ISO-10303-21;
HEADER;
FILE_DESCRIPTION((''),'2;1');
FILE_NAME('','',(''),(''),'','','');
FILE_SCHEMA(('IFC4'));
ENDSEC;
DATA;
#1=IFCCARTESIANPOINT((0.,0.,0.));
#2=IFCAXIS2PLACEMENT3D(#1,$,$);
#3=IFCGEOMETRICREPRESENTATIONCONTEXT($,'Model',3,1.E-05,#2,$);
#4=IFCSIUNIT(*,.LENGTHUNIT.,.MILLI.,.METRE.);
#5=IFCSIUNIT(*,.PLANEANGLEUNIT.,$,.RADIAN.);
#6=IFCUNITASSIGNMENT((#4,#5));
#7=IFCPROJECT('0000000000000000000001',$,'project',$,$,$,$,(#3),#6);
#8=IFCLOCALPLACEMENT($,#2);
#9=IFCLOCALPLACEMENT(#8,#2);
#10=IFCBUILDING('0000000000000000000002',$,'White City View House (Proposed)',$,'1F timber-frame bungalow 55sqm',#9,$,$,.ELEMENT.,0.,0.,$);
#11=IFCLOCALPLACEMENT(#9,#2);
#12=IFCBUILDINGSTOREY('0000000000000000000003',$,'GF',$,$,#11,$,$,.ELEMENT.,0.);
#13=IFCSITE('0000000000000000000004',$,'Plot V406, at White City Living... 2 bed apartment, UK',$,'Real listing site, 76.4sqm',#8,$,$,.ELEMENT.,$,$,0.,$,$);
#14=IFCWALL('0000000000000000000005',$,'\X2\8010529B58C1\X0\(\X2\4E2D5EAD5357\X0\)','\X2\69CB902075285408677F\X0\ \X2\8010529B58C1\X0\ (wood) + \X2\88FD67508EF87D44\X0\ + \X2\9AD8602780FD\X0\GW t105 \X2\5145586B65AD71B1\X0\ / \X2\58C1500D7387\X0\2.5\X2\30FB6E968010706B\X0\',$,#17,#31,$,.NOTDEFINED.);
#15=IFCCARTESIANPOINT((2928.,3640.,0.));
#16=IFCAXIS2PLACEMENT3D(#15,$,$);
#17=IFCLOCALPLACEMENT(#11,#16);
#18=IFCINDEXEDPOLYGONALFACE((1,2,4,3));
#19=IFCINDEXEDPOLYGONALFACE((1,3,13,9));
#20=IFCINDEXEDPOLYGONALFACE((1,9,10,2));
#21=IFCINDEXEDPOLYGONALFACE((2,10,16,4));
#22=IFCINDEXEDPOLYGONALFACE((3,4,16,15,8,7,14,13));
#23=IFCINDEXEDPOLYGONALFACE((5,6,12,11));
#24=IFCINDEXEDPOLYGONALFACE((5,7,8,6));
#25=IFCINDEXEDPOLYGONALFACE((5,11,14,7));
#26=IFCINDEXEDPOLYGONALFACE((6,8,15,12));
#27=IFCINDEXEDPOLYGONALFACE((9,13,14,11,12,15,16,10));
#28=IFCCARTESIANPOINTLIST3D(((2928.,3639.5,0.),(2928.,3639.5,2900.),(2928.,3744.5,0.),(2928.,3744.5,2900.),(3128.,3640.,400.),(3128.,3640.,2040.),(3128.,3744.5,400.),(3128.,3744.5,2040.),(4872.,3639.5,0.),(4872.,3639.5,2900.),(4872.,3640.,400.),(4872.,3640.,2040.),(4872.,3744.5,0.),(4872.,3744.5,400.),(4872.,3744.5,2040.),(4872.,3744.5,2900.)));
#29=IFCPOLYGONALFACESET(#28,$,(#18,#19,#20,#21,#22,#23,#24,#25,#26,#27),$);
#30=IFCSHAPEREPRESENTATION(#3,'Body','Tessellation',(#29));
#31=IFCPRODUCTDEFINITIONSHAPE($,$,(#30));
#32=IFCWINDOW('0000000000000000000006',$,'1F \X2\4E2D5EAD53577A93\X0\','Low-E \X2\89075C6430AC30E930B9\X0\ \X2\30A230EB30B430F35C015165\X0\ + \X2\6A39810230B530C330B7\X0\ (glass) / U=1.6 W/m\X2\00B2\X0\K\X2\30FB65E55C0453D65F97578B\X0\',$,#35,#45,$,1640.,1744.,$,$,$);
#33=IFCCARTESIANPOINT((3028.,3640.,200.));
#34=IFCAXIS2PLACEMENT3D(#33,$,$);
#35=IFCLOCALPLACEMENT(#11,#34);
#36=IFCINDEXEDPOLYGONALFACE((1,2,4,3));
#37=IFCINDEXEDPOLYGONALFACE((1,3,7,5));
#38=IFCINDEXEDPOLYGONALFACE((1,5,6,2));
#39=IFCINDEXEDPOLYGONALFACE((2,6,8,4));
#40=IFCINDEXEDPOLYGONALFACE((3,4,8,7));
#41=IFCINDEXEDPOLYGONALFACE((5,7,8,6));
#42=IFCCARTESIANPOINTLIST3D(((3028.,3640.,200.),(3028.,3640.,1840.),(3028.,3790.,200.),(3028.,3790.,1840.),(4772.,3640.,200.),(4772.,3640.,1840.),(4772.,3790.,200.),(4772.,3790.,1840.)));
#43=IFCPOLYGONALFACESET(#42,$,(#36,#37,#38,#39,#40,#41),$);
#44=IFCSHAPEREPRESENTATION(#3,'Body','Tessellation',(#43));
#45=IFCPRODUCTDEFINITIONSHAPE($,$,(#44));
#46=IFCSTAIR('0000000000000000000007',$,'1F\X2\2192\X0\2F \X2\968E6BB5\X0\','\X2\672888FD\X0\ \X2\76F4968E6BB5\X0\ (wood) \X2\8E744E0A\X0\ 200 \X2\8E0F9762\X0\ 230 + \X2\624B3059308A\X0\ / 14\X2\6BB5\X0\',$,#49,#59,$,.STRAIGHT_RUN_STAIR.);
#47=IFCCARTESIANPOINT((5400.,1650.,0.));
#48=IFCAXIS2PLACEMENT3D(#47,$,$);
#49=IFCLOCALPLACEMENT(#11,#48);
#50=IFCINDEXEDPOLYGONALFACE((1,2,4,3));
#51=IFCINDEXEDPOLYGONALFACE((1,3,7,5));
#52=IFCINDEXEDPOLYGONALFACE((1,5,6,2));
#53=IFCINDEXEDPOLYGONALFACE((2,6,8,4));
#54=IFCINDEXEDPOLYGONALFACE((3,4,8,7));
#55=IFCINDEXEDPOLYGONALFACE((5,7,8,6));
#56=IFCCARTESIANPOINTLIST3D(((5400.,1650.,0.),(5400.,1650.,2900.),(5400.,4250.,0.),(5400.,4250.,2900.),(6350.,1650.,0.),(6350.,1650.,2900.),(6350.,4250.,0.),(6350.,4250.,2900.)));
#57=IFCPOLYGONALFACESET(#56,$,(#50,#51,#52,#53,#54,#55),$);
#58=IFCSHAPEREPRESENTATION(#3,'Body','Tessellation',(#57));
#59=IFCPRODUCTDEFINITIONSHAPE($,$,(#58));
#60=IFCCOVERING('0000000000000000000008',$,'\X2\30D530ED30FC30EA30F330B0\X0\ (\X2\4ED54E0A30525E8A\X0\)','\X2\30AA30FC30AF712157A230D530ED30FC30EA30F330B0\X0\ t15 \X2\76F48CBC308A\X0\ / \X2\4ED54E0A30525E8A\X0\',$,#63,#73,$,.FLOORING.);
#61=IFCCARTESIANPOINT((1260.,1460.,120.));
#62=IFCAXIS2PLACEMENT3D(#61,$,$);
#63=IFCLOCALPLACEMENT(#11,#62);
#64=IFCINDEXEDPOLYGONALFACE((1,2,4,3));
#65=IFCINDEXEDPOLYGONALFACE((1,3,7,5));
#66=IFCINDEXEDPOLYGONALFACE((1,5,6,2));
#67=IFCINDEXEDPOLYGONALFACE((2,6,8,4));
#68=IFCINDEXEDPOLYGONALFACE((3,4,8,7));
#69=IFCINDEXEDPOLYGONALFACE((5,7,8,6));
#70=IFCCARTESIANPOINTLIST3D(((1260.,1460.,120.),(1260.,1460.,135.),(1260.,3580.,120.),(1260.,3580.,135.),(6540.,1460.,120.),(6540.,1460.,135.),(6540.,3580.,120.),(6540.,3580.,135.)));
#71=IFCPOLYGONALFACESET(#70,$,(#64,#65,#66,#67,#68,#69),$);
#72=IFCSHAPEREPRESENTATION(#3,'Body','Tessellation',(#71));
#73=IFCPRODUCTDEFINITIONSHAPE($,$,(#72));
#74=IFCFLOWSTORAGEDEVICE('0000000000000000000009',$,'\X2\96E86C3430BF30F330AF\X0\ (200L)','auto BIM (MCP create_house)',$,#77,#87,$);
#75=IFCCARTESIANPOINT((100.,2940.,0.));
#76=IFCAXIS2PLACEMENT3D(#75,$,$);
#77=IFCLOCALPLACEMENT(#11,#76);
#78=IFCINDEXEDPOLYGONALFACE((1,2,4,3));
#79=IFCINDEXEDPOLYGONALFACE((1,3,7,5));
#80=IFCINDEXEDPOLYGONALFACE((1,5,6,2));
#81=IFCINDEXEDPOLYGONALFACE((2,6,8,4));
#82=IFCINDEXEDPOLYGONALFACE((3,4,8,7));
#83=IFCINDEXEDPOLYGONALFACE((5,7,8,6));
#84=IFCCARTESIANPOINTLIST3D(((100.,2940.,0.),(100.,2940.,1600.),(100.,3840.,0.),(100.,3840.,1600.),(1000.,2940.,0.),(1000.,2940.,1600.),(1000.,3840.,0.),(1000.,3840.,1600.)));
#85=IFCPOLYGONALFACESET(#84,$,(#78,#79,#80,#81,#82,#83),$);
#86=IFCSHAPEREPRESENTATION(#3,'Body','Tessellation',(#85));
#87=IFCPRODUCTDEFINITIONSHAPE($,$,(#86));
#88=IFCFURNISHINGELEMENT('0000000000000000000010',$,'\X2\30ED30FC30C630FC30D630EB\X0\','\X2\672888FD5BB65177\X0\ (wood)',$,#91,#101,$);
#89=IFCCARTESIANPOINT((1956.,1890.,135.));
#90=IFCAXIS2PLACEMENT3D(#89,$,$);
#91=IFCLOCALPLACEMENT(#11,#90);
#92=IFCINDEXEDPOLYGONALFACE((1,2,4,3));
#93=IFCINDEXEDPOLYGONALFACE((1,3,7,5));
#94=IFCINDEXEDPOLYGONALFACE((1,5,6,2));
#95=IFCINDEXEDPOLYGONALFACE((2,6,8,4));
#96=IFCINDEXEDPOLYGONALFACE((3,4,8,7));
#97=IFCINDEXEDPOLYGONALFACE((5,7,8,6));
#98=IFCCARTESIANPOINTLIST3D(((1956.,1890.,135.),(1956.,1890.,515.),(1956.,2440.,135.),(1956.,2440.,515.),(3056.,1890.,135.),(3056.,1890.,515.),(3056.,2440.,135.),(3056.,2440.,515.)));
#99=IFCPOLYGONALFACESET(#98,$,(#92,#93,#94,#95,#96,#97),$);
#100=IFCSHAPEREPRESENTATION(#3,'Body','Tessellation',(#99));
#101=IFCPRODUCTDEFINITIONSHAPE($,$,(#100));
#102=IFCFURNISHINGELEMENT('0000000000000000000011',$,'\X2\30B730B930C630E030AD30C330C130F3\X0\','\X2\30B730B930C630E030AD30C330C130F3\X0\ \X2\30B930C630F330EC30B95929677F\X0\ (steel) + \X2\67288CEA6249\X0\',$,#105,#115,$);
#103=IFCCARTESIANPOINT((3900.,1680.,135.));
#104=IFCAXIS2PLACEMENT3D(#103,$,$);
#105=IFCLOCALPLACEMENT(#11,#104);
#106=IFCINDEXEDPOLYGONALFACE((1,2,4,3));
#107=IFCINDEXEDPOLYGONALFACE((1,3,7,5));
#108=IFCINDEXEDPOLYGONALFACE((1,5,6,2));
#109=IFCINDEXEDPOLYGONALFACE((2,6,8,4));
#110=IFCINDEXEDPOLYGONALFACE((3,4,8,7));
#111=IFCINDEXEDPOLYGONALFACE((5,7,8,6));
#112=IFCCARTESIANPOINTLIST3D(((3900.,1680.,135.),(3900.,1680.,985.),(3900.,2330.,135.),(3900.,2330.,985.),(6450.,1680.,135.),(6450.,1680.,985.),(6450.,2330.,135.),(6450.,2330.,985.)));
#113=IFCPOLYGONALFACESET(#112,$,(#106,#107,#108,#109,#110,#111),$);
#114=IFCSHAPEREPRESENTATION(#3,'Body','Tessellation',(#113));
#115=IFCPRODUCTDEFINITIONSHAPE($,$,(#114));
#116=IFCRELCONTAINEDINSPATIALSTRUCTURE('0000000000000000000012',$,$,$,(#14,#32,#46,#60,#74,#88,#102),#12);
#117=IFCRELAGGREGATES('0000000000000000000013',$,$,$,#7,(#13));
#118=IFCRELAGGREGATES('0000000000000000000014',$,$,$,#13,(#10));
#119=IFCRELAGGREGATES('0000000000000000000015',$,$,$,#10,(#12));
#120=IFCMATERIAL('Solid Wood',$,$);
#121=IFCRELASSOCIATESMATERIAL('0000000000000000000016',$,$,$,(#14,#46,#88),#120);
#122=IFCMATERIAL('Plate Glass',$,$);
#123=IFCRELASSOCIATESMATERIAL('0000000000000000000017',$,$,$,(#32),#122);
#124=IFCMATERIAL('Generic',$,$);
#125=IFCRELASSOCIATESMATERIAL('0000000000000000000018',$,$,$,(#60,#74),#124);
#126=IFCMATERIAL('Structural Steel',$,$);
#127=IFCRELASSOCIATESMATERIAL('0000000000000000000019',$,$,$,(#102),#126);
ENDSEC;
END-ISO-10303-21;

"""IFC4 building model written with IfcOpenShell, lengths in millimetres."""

from ifc_helpers import new_model, si_unit, frame, frame_2d, origin, place, context, project, spatial, rectangle, extrude, material, element, fill, save


model = new_model("IFC4")

# Units and contexts
model_context = context("Model", 3, precision=1e-05, world=origin())
ifc_project = project(units=[si_unit("LENGTHUNIT", "METRE", prefix="MILLI"), si_unit("PLANEANGLEUNIT", "RADIAN")], contexts=[model_context])

# Site, building, storey
site_placement = place(None, origin())
site = spatial("IfcSite", under=ifc_project, at=site_placement, Name="Plot V406, at White City Living... 2 bed apartment, UK", ObjectType="Real listing site, 76.4sqm", CompositionType="ELEMENT", RefElevation=0.0)
building_placement = place(site_placement, origin())
building = spatial("IfcBuilding", under=site, at=building_placement, Name="White City View House (Proposed)", ObjectType="1F timber-frame bungalow 55sqm", CompositionType="ELEMENT", ElevationOfRefHeight=0.0, ElevationOfTerrain=0.0)
storey_placement = place(building_placement, origin())
storey = spatial("IfcBuildingStorey", under=building, at=storey_placement, Name="GF", CompositionType="ELEMENT", Elevation=0.0)

# Shared definitions
ifc_material_1 = material(Name="Solid Wood")

# Shared definitions
ifc_material_2 = material(Name="Plate Glass")

# Wall, opening, window
wall_1_placement = place(storey_placement, frame((2928.0, 3640.0, 0.0)))
wall_1 = element("IfcWall", 1, at=wall_1_placement, inside=storey, material=ifc_material_1, Name="耐力壁(中庭南)", Description="構造用合板 耐力壁 (wood) + 製材軸組 + 高性能GW t105 充填断熱 / 壁倍率2.5・準耐火", PredefinedType="NOTDEFINED", context=model_context, shape_type="SweptSolid", body=[
    extrude(rectangle(XDim=1944.0, YDim=105.0, at=frame_2d((972.0, 52.0))), frame((2928.0, 3640.0, 0.0)), (0.0, 0.0, 1.0), 2900.0),
])
opening_1_placement = place(storey_placement, frame((3028.0, 3640.0, 200.0)))
opening_1 = element("IfcOpeningElement", 2, at=opening_1_placement, cuts=wall_1, PredefinedType="NOTDEFINED", context=model_context, shape_type="SweptSolid", body=[
    extrude(rectangle(XDim=1744.0, YDim=150.0, at=frame_2d((872.0, 75.0))), frame((3028.0, 3640.0, 200.0)), (0.0, 0.0, 1.0), 1640.0),
])
window_1_placement = place(storey_placement, frame((3028.0, 3640.0, 200.0)))
window_1 = element("IfcWindow", 3, at=window_1_placement, inside=storey, material=ifc_material_2, Name="1F 中庭南窓", Description="Low-E 複層ガラス アルゴン封入 + 樹脂サッシ (glass) / U=1.6 W/m²K・日射取得型", OverallHeight=1640.0, OverallWidth=1744.0, context=model_context, shape_type="SweptSolid", body=[
    extrude(rectangle(XDim=1744.0, YDim=150.0, at=frame_2d((872.0, 75.0))), frame((3028.0, 3640.0, 200.0)), (0.0, 0.0, 1.0), 1640.0),
])
fill(opening_1, window_1)

# Stair
stair_placement = place(storey_placement, frame((5400.0, 1650.0, 0.0)))
element("IfcStair", 4, at=stair_placement, inside=storey, material=ifc_material_1, Name="1F→2F 階段", Description="木製 直階段 (wood) 蹴上 200 踏面 230 + 手すり / 14段", PredefinedType="STRAIGHT_RUN_STAIR", context=model_context, shape_type="SweptSolid", body=[
    extrude(rectangle(XDim=950.0, YDim=2600.0, at=frame_2d((475.0, 1300.0))), frame((5400.0, 1650.0, 0.0)), (0.0, 0.0, 1.0), 2900.0),
])

# Covering
ifc_material_3 = material(Name="Generic")
covering_placement = place(storey_placement, frame((1260.0, 1460.0, 120.0)))
element("IfcCovering", 5, at=covering_placement, inside=storey, material=ifc_material_3, Name="フローリング (仕上げ床)", Description="オーク無垢フローリング t15 直貼り / 仕上げ床", PredefinedType="FLOORING", context=model_context, shape_type="SweptSolid", body=[
    extrude(rectangle(XDim=5280.0, YDim=2120.0, at=frame_2d((2640.0, 1060.0))), frame((1260.0, 1460.0, 120.0)), (0.0, 0.0, 1.0), 15.0),
])

# Flow storage device
flow_storage_device_placement = place(storey_placement, frame((100.0, 2940.0, 0.0)))
element("IfcFlowStorageDevice", 6, at=flow_storage_device_placement, inside=storey, material=ifc_material_3, Name="雨水タンク (200L)", Description="auto BIM (MCP create_house)", context=model_context, shape_type="SweptSolid", body=[
    extrude(rectangle(XDim=900.0, YDim=900.0, at=frame_2d((450.0, 450.0))), frame((100.0, 2940.0, 0.0)), (0.0, 0.0, 1.0), 1600.0),
])

# Furnishing elements
furnishing_1_placement = place(storey_placement, frame((1956.0, 1890.0, 135.0)))
element("IfcFurnishingElement", 7, at=furnishing_1_placement, inside=storey, material=ifc_material_1, Name="ローテーブル", Description="木製家具 (wood)", context=model_context, shape_type="SweptSolid", body=[
    extrude(rectangle(XDim=1100.0, YDim=550.0, at=frame_2d((550.0, 275.0))), frame((1956.0, 1890.0, 135.0)), (0.0, 0.0, 1.0), 380.0),
])
ifc_material_4 = material(Name="Structural Steel")
furnishing_2_placement = place(storey_placement, frame((3900.0, 1680.0, 135.0)))
element("IfcFurnishingElement", 8, at=furnishing_2_placement, inside=storey, material=ifc_material_4, Name="システムキッチン", Description="システムキッチン ステンレス天板 (steel) + 木質扉", context=model_context, shape_type="SweptSolid", body=[
    extrude(rectangle(XDim=2550.0, YDim=650.0, at=frame_2d((1275.0, 325.0))), frame((3900.0, 1680.0, 135.0)), (0.0, 0.0, 1.0), 850.0),
])

save(model, "model.ifc")
